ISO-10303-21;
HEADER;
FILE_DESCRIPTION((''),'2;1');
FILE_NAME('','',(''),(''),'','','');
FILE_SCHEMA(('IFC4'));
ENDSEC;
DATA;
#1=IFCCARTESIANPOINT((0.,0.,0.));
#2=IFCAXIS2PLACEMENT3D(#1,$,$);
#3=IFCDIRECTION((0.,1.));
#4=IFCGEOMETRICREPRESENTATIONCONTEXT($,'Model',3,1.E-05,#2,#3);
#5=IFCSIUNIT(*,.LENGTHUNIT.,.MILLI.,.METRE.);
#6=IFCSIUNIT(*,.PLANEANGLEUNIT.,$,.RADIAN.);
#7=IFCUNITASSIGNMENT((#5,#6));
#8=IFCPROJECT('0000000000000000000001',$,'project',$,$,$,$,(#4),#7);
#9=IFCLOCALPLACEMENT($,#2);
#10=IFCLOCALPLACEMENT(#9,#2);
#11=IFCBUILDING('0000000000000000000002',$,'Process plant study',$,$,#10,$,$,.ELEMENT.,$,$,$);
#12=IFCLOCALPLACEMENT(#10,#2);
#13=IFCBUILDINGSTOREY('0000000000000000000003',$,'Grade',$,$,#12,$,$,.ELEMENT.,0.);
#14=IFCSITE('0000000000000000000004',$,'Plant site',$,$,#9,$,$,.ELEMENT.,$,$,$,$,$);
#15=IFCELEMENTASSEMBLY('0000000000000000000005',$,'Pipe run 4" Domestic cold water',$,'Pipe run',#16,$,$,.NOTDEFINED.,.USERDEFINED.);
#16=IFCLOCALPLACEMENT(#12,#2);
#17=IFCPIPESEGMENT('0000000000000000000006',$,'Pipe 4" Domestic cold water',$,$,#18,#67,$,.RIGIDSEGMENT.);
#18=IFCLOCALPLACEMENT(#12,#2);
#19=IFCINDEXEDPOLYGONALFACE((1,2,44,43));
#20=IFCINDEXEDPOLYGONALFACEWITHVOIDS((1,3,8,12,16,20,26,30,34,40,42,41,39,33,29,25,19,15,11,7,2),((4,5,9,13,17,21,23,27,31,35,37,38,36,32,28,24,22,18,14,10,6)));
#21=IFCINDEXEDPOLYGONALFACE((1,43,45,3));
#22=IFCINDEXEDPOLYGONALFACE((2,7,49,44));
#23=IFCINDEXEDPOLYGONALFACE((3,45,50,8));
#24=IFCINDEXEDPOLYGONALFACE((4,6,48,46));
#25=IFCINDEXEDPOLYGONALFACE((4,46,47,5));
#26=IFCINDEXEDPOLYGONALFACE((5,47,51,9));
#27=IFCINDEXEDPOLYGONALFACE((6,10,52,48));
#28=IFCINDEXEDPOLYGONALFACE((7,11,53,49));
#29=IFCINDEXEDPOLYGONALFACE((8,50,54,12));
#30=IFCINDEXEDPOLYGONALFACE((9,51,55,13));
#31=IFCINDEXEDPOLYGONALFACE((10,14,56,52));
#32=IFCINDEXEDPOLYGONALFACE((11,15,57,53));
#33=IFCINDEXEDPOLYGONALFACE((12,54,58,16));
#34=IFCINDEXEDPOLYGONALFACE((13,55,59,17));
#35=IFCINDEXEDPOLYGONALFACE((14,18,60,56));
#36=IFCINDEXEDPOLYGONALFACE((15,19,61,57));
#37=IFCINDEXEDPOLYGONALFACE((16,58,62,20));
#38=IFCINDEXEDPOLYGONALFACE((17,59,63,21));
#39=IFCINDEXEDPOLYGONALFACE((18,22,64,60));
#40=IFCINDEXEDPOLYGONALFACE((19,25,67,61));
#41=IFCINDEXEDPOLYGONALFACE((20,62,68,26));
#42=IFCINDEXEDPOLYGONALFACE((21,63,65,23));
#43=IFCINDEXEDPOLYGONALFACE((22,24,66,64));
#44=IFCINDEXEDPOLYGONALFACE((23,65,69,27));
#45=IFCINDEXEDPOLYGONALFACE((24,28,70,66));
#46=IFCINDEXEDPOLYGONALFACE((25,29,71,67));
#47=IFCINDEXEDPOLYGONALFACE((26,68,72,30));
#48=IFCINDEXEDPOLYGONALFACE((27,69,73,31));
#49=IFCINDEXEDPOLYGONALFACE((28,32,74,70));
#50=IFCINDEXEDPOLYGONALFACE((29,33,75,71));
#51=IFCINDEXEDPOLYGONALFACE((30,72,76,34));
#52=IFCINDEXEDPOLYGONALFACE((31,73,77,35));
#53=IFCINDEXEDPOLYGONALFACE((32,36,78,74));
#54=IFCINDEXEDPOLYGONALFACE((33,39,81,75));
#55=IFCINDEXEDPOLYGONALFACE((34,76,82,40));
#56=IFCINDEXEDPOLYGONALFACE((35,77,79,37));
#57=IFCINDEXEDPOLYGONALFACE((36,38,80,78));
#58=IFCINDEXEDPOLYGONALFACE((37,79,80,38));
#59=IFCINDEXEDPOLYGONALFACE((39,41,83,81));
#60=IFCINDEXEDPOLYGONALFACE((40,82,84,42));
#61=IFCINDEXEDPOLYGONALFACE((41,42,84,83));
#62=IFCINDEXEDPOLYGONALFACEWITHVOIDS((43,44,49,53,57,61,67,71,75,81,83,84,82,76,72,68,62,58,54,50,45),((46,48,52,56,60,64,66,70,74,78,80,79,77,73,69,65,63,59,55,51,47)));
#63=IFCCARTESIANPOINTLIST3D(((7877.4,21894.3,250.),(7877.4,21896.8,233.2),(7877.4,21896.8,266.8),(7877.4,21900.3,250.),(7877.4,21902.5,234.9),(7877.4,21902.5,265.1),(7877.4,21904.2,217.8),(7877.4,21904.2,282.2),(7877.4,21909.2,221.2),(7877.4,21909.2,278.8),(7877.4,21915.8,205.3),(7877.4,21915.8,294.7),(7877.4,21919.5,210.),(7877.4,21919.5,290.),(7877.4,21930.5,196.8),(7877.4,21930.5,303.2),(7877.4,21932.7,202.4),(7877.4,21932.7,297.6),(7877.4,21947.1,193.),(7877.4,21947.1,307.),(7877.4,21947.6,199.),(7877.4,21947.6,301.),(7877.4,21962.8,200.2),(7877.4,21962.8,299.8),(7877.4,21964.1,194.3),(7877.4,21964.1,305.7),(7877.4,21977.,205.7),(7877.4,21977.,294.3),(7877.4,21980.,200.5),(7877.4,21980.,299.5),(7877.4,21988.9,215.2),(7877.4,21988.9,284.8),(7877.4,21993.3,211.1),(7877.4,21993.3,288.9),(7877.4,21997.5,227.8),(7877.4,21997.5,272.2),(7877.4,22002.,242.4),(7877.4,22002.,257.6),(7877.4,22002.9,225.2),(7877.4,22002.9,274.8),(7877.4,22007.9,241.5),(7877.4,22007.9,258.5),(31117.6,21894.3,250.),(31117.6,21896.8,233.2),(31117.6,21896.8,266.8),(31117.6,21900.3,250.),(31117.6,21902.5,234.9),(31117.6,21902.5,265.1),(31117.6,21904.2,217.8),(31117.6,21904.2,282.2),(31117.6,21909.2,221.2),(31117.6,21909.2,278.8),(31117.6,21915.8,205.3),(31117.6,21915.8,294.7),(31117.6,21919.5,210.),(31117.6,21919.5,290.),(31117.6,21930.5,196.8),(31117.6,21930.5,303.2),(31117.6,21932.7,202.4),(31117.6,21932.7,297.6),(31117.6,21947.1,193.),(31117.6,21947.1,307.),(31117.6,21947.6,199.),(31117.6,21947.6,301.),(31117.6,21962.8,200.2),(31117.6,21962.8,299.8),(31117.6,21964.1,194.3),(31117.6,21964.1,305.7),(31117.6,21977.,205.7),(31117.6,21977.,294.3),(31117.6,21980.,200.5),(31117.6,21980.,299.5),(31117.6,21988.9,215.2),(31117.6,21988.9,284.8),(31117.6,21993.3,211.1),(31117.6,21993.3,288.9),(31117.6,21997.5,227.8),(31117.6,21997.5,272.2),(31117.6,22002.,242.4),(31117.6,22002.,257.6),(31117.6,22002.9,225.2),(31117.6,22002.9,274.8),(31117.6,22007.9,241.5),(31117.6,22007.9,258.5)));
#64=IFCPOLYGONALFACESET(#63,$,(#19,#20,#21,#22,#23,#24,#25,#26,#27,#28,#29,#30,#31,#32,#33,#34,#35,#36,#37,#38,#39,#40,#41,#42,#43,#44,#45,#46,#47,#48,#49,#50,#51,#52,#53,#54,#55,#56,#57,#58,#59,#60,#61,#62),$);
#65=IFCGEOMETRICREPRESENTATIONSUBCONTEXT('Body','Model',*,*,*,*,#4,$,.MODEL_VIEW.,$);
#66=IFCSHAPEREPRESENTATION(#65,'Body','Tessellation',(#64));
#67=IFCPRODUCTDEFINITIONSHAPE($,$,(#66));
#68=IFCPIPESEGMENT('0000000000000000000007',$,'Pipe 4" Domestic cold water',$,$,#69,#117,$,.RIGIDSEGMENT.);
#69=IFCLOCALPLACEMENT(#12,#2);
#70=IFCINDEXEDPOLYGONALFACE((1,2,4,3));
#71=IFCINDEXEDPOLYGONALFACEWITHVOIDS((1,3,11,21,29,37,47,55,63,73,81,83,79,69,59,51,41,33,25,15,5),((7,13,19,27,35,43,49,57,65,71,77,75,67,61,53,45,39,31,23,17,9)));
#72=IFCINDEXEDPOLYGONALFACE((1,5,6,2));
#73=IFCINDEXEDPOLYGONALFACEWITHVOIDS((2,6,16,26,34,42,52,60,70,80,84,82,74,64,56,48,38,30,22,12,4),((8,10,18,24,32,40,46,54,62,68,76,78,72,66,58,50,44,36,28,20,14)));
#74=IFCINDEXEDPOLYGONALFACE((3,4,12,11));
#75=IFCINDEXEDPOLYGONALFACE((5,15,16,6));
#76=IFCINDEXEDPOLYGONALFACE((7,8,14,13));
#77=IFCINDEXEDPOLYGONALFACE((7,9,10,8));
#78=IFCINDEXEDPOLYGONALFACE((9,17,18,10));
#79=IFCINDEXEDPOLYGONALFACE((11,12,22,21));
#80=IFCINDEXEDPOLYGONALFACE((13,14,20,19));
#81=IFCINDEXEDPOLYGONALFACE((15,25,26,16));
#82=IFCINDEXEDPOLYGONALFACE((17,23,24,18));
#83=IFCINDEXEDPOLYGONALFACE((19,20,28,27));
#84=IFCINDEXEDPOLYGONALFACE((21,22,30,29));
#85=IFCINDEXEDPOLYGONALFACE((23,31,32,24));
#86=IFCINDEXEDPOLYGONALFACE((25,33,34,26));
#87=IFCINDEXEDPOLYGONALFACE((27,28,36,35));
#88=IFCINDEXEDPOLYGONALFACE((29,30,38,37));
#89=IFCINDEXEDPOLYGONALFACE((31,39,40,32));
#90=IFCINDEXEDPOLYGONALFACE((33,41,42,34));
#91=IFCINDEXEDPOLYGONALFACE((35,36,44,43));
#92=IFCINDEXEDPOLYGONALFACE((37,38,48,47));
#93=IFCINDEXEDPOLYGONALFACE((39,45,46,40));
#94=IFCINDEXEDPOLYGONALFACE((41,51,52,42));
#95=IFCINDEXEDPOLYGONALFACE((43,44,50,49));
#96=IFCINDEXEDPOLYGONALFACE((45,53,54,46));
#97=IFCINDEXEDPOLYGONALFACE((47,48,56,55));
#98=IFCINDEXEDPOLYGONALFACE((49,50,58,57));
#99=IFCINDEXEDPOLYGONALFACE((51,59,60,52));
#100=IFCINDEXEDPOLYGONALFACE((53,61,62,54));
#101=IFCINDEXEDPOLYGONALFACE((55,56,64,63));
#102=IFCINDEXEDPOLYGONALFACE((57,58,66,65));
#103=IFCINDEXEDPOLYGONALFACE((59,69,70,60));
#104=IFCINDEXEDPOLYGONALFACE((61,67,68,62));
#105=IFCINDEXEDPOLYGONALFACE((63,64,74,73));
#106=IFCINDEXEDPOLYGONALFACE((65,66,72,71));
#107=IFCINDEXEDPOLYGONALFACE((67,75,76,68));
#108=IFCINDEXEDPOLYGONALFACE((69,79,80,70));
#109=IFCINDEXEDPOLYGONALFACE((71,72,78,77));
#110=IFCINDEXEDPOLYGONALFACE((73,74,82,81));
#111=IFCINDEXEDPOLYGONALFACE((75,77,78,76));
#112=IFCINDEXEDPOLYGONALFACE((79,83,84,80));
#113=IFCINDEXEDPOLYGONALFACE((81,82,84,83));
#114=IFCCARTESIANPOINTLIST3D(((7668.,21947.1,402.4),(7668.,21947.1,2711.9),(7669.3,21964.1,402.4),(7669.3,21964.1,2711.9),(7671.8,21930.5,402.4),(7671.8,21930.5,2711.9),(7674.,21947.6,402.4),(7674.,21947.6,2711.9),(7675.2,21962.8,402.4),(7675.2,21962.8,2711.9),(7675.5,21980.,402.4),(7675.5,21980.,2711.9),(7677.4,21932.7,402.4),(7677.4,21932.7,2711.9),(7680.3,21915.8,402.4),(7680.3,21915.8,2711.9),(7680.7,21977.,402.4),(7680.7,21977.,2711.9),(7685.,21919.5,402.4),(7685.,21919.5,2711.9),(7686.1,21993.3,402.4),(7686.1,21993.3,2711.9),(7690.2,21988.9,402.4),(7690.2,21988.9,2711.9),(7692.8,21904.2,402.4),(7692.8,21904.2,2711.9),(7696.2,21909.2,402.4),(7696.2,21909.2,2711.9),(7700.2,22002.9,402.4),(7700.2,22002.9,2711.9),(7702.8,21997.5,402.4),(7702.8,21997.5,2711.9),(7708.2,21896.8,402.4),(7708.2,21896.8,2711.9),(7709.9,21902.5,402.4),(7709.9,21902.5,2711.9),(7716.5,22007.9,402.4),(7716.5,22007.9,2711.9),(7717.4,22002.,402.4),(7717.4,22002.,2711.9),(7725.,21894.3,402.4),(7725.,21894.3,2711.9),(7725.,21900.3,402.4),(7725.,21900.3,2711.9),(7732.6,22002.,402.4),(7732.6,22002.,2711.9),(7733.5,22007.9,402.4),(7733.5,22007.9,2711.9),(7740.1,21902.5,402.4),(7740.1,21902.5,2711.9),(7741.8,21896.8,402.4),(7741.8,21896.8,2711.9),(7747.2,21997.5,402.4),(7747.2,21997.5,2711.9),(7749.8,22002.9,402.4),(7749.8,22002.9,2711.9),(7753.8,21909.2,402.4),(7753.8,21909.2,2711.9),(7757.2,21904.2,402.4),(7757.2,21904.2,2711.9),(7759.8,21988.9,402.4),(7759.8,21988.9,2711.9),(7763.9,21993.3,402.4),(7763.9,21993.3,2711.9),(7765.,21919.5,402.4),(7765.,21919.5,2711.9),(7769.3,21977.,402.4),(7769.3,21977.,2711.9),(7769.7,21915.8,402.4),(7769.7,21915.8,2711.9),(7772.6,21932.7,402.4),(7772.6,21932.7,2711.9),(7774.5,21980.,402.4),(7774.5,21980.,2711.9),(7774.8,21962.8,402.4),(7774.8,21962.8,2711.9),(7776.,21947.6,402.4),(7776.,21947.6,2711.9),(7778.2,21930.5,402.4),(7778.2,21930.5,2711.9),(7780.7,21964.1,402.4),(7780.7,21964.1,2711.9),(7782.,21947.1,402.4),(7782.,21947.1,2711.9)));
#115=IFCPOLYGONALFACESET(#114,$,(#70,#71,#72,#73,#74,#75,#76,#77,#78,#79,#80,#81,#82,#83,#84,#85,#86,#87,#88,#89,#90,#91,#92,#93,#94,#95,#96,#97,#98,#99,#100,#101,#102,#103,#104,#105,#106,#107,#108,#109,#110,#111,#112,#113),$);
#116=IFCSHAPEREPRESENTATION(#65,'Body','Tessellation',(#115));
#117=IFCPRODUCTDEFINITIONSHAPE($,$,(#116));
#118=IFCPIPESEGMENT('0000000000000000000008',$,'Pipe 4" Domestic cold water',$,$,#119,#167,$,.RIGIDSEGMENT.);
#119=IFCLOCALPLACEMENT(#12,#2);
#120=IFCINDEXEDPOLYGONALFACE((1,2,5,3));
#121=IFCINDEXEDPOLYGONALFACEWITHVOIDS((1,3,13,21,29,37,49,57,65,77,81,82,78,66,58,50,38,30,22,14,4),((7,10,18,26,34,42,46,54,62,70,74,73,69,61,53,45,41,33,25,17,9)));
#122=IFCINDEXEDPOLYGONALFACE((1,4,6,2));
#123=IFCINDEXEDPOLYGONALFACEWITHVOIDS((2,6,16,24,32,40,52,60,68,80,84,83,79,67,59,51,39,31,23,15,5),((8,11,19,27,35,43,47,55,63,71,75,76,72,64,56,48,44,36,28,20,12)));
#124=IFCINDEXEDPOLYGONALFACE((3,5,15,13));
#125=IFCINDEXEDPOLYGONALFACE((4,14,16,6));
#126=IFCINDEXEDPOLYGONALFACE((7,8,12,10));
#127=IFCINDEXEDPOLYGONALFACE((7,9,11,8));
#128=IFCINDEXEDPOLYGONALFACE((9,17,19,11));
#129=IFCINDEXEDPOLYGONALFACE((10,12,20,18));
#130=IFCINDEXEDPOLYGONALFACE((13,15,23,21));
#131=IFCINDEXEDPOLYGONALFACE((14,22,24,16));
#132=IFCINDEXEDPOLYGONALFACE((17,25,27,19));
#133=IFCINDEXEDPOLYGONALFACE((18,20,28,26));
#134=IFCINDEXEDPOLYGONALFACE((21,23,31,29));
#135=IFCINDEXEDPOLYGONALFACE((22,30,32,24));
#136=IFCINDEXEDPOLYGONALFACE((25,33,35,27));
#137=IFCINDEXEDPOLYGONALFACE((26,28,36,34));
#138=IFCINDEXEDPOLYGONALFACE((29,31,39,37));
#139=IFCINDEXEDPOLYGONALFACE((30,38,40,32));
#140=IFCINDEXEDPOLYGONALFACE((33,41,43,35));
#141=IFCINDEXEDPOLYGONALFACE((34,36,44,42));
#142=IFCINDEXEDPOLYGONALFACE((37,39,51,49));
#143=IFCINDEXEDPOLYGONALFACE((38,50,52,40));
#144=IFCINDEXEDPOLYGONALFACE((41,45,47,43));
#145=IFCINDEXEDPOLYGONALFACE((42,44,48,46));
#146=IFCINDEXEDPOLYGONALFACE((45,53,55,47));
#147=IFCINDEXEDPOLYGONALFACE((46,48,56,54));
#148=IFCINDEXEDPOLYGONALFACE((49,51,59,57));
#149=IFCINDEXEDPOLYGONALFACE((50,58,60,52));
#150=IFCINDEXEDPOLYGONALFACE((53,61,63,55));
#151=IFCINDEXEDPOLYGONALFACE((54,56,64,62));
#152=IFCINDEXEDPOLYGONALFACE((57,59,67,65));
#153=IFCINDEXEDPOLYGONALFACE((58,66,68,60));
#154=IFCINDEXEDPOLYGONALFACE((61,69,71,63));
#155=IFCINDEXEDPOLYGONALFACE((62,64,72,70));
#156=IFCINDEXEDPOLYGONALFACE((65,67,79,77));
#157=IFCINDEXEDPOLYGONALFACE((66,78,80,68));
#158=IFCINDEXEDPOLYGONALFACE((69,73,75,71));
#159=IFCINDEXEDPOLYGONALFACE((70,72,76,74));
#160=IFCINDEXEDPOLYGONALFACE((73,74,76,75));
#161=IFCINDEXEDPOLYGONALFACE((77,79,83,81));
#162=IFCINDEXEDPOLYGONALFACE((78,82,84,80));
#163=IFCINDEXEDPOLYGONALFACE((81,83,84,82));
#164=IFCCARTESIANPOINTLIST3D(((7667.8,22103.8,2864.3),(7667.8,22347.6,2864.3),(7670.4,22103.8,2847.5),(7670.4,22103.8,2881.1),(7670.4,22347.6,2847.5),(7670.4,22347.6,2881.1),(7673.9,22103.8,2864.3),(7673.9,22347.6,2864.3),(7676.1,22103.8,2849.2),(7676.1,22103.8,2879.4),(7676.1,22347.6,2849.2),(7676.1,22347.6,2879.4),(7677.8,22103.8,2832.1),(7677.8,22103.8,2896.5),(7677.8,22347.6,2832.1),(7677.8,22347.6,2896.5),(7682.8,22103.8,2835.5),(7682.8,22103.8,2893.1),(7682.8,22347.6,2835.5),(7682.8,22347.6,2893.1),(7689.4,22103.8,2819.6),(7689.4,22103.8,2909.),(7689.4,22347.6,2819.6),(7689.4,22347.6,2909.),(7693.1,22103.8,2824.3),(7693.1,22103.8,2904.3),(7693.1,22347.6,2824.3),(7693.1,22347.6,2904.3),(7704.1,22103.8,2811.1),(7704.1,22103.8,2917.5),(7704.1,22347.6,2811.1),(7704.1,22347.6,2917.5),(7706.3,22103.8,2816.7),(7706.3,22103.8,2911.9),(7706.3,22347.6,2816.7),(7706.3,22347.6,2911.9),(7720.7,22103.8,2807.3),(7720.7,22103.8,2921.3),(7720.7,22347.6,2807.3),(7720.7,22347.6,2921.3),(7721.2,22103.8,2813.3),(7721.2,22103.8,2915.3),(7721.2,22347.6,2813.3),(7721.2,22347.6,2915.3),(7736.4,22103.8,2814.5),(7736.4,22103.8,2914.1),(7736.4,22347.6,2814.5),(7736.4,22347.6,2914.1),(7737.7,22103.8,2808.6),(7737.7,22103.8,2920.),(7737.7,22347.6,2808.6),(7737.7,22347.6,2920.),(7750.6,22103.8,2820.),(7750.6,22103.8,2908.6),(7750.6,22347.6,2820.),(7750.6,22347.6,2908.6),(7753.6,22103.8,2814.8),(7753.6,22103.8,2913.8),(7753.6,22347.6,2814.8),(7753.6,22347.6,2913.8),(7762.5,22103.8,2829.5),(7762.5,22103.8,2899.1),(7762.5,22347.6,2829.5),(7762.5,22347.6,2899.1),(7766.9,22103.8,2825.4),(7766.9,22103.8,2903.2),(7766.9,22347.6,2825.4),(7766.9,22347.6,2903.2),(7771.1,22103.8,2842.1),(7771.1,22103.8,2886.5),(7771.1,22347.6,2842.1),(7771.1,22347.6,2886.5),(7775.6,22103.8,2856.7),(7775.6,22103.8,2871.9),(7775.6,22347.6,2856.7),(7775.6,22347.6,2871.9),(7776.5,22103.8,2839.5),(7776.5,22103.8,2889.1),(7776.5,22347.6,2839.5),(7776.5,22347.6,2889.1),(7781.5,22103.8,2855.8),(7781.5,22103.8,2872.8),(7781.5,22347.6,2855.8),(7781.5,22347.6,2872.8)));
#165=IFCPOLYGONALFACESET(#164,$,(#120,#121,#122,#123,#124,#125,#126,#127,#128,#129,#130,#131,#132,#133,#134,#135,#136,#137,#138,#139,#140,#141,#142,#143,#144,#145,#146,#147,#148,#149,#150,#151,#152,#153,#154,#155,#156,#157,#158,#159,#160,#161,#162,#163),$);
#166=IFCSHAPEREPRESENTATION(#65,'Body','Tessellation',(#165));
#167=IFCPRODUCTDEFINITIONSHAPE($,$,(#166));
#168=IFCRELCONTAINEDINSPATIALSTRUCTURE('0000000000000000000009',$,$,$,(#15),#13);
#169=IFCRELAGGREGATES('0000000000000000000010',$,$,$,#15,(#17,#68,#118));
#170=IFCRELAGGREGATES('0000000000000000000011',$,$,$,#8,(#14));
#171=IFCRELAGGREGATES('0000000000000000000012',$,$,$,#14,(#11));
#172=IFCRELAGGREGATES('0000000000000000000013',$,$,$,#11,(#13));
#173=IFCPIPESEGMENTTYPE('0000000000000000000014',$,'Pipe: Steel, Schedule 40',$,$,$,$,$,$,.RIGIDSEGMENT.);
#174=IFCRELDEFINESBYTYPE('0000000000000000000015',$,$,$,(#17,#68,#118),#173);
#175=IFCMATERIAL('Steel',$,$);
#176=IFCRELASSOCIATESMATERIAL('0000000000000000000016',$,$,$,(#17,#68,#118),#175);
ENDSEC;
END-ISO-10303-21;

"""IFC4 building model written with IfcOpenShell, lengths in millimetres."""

from ifc_helpers import new_model, si_unit, direction, frame, origin, origin_with_axes, origin_2d, place, context, subcontext, project, spatial, hollow_circle, extrude, material, type_object, element, aggregate, save


model = new_model("IFC4")

# Units and contexts
model_context = context("Model", 3, precision=1e-05, world=origin(), true_north=direction((0.0, 1.0)))
body_context = subcontext(model_context, "Body", "Model", "MODEL_VIEW")
ifc_project = project(units=[si_unit("LENGTHUNIT", "METRE", prefix="MILLI"), si_unit("PLANEANGLEUNIT", "RADIAN")], contexts=[model_context])

# Site, building, storey
site_placement = place(None, origin())
site = spatial("IfcSite", under=ifc_project, at=site_placement, Name="Plant site", CompositionType="ELEMENT")
building_placement = place(site_placement, origin())
building = spatial("IfcBuilding", under=site, at=building_placement, Name="Process plant study", CompositionType="ELEMENT")
storey_placement = place(building_placement, origin())
storey = spatial("IfcBuildingStorey", under=building, at=storey_placement, Name="Grade", CompositionType="ELEMENT", Elevation=0.0)

# Element assembly, pipe segments
assembly_1_placement = place(storey_placement, origin_with_axes())
assembly_1 = element("IfcElementAssembly", 1, at=assembly_1_placement, inside=storey, Name="Pipe run 4\" Domestic cold water", ObjectType="Pipe run", AssemblyPlace="NOTDEFINED", PredefinedType="USERDEFINED")
ifc_material = material(Name="Steel")
pipe_segment_type = type_object("IfcPipeSegmentType", Name="Pipe: Steel, Schedule 40", PredefinedType="RIGIDSEGMENT")
pipe_segment_1_placement = place(storey_placement, origin_with_axes())
pipe_segment_1 = element("IfcPipeSegment", 2, at=pipe_segment_1_placement, type_object=pipe_segment_type, material=ifc_material, Name="Pipe 4\" Domestic cold water", PredefinedType="RIGIDSEGMENT", context=body_context, shape_type="SweptSolid", body=[
    extrude(hollow_circle(Radius=57.1, WallThickness=6.0, at=origin_2d()), frame((31117.6, 21951.4, 250.0), z_axis=(-1.0, 0.0, 0.0), x_axis=(0.0, -1.0, 0.0)), (0.0, 0.0, 1.0), 23240.2),
])
pipe_segment_2_placement = place(storey_placement, origin_with_axes())
pipe_segment_2 = element("IfcPipeSegment", 3, at=pipe_segment_2_placement, type_object=pipe_segment_type, material=ifc_material, Name="Pipe 4\" Domestic cold water", PredefinedType="RIGIDSEGMENT", context=body_context, shape_type="SweptSolid", body=[
    extrude(hollow_circle(Radius=57.1, WallThickness=6.0, at=origin_2d()), frame((7725.0, 21951.4, 402.4), z_axis=(0.0, 0.0, 1.0), x_axis=(0.0, -1.0, 0.0)), (0.0, 0.0, 1.0), 2309.5),
])
pipe_segment_3_placement = place(storey_placement, origin_with_axes())
pipe_segment_3 = element("IfcPipeSegment", 4, at=pipe_segment_3_placement, type_object=pipe_segment_type, material=ifc_material, Name="Pipe 4\" Domestic cold water", PredefinedType="RIGIDSEGMENT", context=body_context, shape_type="SweptSolid", body=[
    extrude(hollow_circle(Radius=57.1, WallThickness=6.0, at=origin_2d()), frame((7725.0, 22103.8, 2864.3), z_axis=(0.0, 1.0, 0.0), x_axis=(-1.0, 0.0, 0.0)), (0.0, 0.0, 1.0), 243.8),
])

aggregate(assembly_1, [pipe_segment_1, pipe_segment_2, pipe_segment_3])

save(model, "model.ifc")
